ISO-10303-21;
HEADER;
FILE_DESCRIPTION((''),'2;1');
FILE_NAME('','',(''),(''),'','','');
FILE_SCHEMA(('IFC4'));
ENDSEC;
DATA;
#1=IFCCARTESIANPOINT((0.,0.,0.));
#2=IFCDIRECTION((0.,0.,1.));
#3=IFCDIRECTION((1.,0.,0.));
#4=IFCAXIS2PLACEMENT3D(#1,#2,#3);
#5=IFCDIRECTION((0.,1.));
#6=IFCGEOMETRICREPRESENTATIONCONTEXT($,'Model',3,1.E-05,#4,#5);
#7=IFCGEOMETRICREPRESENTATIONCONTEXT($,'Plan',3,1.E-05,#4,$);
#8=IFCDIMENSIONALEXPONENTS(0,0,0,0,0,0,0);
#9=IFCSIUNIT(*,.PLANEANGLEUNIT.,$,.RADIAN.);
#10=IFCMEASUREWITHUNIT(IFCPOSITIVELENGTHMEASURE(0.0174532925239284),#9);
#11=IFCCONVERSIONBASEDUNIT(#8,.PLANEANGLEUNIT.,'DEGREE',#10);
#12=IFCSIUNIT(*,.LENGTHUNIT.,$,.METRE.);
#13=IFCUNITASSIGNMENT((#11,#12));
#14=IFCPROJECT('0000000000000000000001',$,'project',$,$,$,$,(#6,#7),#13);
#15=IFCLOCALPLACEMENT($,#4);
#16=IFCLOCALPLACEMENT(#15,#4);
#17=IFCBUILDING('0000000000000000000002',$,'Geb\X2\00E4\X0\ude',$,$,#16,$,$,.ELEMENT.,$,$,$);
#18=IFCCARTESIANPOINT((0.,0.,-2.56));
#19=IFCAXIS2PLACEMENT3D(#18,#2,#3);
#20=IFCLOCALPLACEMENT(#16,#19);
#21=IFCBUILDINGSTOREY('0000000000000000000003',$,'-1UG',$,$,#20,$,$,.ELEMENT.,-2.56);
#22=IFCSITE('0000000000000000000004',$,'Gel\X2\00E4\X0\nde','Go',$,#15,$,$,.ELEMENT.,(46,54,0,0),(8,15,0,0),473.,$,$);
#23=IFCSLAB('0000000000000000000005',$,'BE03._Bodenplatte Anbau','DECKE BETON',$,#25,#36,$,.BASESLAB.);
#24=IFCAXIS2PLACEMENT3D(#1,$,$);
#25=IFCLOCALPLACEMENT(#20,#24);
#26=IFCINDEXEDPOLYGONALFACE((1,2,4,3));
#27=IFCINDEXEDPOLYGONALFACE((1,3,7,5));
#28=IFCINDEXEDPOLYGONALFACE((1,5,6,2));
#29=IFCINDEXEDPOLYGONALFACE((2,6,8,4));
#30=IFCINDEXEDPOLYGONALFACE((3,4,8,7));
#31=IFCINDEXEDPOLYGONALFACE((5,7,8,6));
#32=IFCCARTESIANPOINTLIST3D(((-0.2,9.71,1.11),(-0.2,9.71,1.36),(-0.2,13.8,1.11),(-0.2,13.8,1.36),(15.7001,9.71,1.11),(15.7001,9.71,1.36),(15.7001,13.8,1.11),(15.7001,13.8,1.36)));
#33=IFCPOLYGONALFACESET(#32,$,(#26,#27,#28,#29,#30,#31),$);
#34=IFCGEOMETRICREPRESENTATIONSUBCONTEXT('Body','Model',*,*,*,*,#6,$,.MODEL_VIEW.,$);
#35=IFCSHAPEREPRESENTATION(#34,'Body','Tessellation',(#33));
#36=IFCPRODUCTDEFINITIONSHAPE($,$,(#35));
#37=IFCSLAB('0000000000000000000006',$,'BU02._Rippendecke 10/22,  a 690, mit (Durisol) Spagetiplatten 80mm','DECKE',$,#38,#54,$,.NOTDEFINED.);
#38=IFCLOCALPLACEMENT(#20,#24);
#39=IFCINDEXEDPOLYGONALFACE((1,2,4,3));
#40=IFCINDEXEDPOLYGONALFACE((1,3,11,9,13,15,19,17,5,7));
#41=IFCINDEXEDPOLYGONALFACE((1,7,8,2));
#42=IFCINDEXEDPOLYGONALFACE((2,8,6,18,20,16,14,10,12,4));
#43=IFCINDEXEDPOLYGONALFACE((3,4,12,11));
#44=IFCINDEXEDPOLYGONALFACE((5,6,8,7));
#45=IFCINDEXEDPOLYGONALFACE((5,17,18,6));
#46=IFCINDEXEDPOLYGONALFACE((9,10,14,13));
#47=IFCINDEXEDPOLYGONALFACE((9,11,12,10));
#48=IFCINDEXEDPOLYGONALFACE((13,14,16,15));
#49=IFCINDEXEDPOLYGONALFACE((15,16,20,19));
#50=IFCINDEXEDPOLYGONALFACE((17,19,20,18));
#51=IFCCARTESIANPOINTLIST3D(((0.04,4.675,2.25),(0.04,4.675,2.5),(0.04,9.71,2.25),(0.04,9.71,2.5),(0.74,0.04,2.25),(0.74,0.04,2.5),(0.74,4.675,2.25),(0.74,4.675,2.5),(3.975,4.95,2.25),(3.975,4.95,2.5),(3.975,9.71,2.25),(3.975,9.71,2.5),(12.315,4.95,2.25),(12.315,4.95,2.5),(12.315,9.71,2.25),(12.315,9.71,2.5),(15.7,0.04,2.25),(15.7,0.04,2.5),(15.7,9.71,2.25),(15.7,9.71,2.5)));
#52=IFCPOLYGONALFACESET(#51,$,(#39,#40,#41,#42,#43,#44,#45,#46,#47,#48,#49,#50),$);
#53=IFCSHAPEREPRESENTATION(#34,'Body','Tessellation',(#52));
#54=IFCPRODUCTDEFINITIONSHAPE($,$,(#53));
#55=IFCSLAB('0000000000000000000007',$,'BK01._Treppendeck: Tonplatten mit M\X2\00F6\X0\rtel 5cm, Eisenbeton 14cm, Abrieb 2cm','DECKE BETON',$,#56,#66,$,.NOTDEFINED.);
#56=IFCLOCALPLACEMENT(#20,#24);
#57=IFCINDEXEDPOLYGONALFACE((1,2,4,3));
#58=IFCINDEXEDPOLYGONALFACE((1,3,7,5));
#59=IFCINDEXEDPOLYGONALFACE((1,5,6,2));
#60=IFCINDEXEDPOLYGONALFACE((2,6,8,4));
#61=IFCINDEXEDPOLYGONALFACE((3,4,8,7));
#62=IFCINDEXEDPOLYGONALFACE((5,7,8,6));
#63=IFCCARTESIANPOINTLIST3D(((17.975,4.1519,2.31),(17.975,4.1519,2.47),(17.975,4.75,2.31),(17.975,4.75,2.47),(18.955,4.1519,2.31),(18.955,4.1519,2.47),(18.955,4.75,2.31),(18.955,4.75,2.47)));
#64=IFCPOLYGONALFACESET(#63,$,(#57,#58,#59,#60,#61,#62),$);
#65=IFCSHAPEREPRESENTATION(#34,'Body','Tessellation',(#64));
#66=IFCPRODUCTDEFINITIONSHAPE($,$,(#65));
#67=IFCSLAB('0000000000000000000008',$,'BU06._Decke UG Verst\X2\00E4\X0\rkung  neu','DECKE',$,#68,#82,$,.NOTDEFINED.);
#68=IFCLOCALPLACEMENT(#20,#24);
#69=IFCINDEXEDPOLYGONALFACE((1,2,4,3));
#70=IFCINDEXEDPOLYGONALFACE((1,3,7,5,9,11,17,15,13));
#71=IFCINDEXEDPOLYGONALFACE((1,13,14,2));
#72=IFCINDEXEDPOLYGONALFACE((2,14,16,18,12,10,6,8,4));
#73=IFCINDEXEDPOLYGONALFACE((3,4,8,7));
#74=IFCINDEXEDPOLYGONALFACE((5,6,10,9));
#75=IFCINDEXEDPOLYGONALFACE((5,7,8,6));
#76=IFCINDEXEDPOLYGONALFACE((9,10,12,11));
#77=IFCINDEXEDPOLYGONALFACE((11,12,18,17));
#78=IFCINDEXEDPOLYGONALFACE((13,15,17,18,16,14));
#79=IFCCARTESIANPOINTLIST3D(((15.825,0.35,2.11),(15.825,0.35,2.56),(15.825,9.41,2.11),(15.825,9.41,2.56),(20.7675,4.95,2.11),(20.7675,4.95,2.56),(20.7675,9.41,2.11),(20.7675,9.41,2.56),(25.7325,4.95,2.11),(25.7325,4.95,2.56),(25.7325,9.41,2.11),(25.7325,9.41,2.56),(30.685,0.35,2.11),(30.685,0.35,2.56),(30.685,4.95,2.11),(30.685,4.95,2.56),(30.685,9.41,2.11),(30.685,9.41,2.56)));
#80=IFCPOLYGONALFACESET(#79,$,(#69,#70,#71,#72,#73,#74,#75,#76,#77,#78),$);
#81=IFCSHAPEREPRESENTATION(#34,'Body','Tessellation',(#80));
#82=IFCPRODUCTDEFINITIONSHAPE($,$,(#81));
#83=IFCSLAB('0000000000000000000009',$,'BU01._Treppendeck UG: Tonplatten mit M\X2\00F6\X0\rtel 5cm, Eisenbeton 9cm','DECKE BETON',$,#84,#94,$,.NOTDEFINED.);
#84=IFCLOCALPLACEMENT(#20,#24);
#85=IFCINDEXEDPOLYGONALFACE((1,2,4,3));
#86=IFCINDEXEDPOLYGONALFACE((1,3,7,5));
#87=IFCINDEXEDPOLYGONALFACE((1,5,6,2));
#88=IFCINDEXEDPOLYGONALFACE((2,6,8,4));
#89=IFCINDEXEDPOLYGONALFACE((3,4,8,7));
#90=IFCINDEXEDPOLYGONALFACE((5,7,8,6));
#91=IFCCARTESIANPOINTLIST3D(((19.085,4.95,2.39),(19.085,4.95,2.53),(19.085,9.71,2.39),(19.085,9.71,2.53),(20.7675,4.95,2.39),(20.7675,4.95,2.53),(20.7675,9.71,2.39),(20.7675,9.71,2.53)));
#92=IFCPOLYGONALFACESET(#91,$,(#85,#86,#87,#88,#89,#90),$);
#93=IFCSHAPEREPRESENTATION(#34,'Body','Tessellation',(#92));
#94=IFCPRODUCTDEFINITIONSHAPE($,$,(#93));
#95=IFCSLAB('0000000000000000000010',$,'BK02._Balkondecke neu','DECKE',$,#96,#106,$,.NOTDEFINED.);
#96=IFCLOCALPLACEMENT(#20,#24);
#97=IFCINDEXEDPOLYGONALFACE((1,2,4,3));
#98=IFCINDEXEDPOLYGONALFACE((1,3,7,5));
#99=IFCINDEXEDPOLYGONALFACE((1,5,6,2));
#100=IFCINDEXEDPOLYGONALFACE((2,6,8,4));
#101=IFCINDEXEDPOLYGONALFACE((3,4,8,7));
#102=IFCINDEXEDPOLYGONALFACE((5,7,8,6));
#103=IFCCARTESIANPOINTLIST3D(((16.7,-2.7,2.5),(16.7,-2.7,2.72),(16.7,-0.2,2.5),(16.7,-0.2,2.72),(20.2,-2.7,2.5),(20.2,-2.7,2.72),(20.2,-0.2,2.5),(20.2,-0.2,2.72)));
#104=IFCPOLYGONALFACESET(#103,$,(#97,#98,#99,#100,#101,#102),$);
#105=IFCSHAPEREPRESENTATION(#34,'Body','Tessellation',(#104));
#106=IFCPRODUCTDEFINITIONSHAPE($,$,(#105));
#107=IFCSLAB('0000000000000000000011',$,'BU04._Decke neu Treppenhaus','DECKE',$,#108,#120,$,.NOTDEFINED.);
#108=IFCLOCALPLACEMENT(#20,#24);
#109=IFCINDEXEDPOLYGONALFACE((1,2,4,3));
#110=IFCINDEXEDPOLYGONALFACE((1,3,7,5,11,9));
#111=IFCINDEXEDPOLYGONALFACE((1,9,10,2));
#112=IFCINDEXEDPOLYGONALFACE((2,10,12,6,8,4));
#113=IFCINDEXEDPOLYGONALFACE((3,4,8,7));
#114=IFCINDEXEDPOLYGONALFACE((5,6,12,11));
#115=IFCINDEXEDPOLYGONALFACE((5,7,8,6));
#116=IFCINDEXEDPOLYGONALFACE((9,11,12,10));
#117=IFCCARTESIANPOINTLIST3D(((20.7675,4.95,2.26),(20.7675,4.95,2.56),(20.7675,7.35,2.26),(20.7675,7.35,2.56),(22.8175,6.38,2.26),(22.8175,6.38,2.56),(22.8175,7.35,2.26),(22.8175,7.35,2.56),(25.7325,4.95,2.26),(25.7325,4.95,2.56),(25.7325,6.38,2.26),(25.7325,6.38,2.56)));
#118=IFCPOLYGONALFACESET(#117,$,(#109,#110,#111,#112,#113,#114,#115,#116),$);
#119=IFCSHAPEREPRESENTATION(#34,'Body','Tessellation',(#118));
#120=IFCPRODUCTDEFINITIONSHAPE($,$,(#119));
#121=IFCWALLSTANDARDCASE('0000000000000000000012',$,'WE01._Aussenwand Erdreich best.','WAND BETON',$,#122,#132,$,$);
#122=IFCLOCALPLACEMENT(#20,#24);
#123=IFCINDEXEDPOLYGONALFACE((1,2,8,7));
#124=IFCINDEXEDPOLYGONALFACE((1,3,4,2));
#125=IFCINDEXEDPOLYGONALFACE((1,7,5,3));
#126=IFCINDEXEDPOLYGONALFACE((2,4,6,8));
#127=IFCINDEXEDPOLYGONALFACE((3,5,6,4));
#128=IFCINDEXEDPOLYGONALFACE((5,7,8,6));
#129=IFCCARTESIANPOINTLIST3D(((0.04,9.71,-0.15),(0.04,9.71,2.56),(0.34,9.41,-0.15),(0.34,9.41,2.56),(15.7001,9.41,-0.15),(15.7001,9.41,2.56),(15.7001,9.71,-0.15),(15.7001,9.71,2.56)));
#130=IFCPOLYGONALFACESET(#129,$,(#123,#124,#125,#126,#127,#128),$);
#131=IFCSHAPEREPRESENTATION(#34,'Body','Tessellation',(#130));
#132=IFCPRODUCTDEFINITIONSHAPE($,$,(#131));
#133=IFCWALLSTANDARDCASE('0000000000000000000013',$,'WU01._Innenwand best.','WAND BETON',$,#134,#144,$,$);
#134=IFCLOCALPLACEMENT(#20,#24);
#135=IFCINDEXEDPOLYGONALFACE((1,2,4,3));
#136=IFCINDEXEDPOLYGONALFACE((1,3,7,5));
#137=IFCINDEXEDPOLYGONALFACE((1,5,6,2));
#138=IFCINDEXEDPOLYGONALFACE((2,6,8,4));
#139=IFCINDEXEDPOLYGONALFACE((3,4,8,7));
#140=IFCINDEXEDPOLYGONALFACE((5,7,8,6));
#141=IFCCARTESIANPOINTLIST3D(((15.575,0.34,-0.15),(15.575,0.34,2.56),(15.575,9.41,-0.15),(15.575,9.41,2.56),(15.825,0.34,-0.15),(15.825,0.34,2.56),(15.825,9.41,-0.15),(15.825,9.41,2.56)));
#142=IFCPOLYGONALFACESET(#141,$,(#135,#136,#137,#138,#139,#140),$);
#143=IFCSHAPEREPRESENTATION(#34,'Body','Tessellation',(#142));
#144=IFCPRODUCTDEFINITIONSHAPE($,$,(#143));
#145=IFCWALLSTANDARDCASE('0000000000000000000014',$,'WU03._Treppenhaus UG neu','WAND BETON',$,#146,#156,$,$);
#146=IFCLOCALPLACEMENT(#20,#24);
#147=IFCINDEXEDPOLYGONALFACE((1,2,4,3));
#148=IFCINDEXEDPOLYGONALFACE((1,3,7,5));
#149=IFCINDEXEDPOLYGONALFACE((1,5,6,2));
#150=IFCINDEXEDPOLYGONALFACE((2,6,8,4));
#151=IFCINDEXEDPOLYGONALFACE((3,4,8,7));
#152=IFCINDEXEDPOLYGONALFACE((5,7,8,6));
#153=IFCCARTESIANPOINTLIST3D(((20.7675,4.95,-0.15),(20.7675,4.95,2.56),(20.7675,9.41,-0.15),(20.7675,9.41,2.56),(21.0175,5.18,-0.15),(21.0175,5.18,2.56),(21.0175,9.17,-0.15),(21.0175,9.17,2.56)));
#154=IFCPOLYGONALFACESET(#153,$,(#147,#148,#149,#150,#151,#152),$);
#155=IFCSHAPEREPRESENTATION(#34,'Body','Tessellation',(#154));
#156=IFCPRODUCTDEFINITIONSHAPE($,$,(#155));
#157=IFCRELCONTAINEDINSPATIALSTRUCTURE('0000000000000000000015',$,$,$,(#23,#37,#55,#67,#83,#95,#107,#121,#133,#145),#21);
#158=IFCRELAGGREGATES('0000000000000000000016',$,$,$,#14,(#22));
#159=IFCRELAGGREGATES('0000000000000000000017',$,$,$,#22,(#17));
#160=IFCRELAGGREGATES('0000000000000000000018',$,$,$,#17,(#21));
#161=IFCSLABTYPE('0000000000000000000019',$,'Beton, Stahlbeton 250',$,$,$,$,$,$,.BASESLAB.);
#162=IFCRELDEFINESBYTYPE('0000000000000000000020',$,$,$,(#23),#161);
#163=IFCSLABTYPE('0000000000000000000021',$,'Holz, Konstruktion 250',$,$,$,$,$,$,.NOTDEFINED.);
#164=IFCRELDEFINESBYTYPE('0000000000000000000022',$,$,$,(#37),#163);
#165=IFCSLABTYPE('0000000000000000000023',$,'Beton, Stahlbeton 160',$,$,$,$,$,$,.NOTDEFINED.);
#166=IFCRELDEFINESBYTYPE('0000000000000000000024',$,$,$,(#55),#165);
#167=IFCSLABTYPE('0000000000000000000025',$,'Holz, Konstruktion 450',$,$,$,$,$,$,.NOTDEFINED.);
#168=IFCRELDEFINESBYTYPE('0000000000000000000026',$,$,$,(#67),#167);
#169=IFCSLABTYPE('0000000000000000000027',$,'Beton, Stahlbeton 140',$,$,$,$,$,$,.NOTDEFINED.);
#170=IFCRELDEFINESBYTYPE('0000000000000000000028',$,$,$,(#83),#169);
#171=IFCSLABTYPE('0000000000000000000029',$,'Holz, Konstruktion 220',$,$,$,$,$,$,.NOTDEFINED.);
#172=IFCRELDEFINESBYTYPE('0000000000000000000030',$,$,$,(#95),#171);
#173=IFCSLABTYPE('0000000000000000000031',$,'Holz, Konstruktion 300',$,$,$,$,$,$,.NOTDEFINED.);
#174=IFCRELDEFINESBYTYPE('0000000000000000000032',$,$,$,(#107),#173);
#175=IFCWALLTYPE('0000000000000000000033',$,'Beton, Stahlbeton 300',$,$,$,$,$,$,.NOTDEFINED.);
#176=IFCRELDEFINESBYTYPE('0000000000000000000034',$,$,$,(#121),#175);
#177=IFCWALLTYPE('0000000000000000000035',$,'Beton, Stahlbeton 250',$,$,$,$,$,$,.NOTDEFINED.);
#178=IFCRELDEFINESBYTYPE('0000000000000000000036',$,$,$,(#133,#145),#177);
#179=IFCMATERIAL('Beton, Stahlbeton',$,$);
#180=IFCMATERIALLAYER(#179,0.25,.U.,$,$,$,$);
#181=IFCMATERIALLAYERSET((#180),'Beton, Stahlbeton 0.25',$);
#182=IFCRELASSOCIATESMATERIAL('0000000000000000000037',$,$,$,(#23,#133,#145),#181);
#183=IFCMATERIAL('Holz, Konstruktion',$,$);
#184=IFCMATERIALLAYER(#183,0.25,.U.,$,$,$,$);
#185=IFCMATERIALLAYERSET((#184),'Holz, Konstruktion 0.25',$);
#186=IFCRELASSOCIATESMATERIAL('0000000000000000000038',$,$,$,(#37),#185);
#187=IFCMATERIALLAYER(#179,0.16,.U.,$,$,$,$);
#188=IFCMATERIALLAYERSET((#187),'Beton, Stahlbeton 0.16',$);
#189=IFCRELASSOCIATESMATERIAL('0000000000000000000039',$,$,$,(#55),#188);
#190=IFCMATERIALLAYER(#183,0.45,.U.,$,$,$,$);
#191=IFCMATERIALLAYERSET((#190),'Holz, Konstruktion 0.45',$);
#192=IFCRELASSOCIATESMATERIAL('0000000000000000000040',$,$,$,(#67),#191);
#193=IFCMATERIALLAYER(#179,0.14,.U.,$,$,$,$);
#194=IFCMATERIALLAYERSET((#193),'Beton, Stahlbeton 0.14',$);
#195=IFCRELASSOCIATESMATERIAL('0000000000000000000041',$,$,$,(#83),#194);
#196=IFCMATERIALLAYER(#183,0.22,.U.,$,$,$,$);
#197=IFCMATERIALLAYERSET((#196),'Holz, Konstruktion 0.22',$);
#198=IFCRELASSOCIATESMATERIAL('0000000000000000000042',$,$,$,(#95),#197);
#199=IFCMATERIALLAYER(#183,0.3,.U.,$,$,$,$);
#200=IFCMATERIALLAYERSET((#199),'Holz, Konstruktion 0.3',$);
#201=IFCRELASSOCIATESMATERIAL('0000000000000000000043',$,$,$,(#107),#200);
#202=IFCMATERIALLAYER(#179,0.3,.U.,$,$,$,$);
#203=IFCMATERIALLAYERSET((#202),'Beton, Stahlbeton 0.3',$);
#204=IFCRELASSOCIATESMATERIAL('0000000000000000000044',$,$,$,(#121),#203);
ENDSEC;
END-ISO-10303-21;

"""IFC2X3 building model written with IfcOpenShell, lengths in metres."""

from ifc_helpers import new_model, entity, si_unit, converted_unit, direction, frame, origin_with_axes, place, context, subcontext, project, spatial, polyline, outline, extrude, material, layer, layer_set, layer_usage, type_object, element, save


model = new_model("IFC2X3")

# Units and contexts
model_context = context("Model", 3, precision=1e-05, world=origin_with_axes(), true_north=direction((0.0, 1.0)))
plan_context = context("Plan", 3, precision=1e-05, world=origin_with_axes())
body_context = subcontext(model_context, "Body", "Model", "MODEL_VIEW")
ifc_project = project(units=[converted_unit("PLANEANGLEUNIT", "DEGREE", entity("IfcPositiveLengthMeasure", 0.0174532925239284), si_unit("PLANEANGLEUNIT", "RADIAN"), dimensions=[0, 0, 0, 0, 0, 0, 0]), si_unit("LENGTHUNIT", "METRE")], contexts=[model_context, plan_context])

# Site, building, storey
site_placement = place(None, origin_with_axes())
site = spatial("IfcSite", under=ifc_project, at=site_placement, Name="Gelände", Description="Go", CompositionType="ELEMENT", RefLatitude=(46, 54, 0, 0), RefLongitude=(8, 15, 0, 0), RefElevation=473.0)
building_placement = place(site_placement, origin_with_axes())
building = spatial("IfcBuilding", under=site, at=building_placement, Name="Gebäude", CompositionType="ELEMENT")
storey_placement = place(building_placement, frame((0.0, 0.0, -2.56), z_axis=(0.0, 0.0, 1.0), x_axis=(1.0, 0.0, 0.0)))
storey = spatial("IfcBuildingStorey", under=building, at=storey_placement, Name="-1UG", CompositionType="ELEMENT", Elevation=-2.56)

# Slabs
ifc_material_1 = material(Name="Beton, Stahlbeton")
ifc_layer_1 = layer(ifc_material_1, 0.25, ventilated="UNKNOWN")
ifc_layer_set_1 = layer_set([ifc_layer_1], Name="Beton, Stahlbeton 0.25")
ifc_layer_usage_1 = layer_usage(ifc_layer_set_1, "AXIS3", "NEGATIVE", 0.25)
slab_type_1 = type_object("IfcSlabType", Name="Beton, Stahlbeton 250", PredefinedType="BASESLAB")
slab_1_placement = place(storey_placement, frame((15.7001, 9.71, 1.36), z_axis=(0.0, 0.0, 1.0), x_axis=(1.0, 0.0, 0.0)))
element("IfcSlab", 1, at=slab_1_placement, inside=storey, type_object=slab_type_1, material=ifc_layer_usage_1, Name="BE03._Bodenplatte Anbau", Description="DECKE BETON", PredefinedType="BASESLAB", context=body_context, shape_type="SweptSolid", body=[
    extrude(outline(polyline([(0.0, 0.0), (0.0, 4.09), (-15.9001, 4.09), (-15.9001, 0.0), (0.0, 0.0)])), frame((0.0, 0.0, -0.25), z_axis=(0.0, 0.0, 1.0), x_axis=(1.0, 0.0, 0.0)), (0.0, 0.0, 1.0), 0.25),
])
ifc_material_2 = material(Name="Holz, Konstruktion")
ifc_layer_2 = layer(ifc_material_2, 0.25, ventilated="UNKNOWN")
ifc_layer_set_2 = layer_set([ifc_layer_2], Name="Holz, Konstruktion 0.25")
ifc_layer_usage_2 = layer_usage(ifc_layer_set_2, "AXIS3", "NEGATIVE", 0.25)
slab_type_2 = type_object("IfcSlabType", Name="Holz, Konstruktion 250", PredefinedType="NOTDEFINED")
slab_2_placement = place(storey_placement, frame((15.7, 0.04, 2.5), z_axis=(0.0, 0.0, 1.0), x_axis=(1.0, 0.0, 0.0)))
element("IfcSlab", 2, at=slab_2_placement, inside=storey, type_object=slab_type_2, material=ifc_layer_usage_2, Name="BU02._Rippendecke 10/22,  a 690, mit (Durisol) Spagetiplatten 80mm", Description="DECKE", PredefinedType="NOTDEFINED", context=body_context, shape_type="SweptSolid", body=[
    extrude(outline(polyline([(0.0, 0.0), (0.0, 9.67), (-3.385, 9.67), (-3.385, 4.91), (-11.725, 4.91), (-11.725, 9.67), (-15.66, 9.67), (-15.66, 4.635), (-14.96, 4.635), (-14.96, 0.0), (0.0, 0.0)])), frame((0.0, 0.0, -0.25), z_axis=(0.0, 0.0, 1.0), x_axis=(1.0, 0.0, 0.0)), (0.0, 0.0, 1.0), 0.25),
])
ifc_layer_3 = layer(ifc_material_1, 0.16, ventilated="UNKNOWN")
ifc_layer_set_3 = layer_set([ifc_layer_3], Name="Beton, Stahlbeton 0.16")
ifc_layer_usage_3 = layer_usage(ifc_layer_set_3, "AXIS3", "NEGATIVE", 0.16)
slab_type_3 = type_object("IfcSlabType", Name="Beton, Stahlbeton 160", PredefinedType="NOTDEFINED")
slab_3_placement = place(storey_placement, frame((18.955, 4.1519, 2.47), z_axis=(0.0, 0.0, 1.0), x_axis=(1.0, 0.0, 0.0)))
element("IfcSlab", 3, at=slab_3_placement, inside=storey, type_object=slab_type_3, material=ifc_layer_usage_3, Name="BK01._Treppendeck: Tonplatten mit Mörtel 5cm, Eisenbeton 14cm, Abrieb 2cm", Description="DECKE BETON", PredefinedType="NOTDEFINED", context=body_context, shape_type="SweptSolid", body=[
    extrude(outline(polyline([(0.0, 0.0), (0.0, 0.5981), (-0.98, 0.5981), (-0.98, 0.0), (0.0, 0.0)])), frame((0.0, 0.0, -0.16), z_axis=(0.0, 0.0, 1.0), x_axis=(1.0, 0.0, 0.0)), (0.0, 0.0, 1.0), 0.16),
])
ifc_layer_4 = layer(ifc_material_2, 0.45, ventilated="UNKNOWN")
ifc_layer_set_4 = layer_set([ifc_layer_4], Name="Holz, Konstruktion 0.45")
ifc_layer_usage_4 = layer_usage(ifc_layer_set_4, "AXIS3", "NEGATIVE", 0.45)
slab_type_4 = type_object("IfcSlabType", Name="Holz, Konstruktion 450", PredefinedType="NOTDEFINED")
slab_4_placement = place(storey_placement, frame((15.825, 0.35, 2.56), z_axis=(0.0, 0.0, 1.0), x_axis=(1.0, 0.0, 0.0)))
element("IfcSlab", 4, at=slab_4_placement, inside=storey, type_object=slab_type_4, material=ifc_layer_usage_4, Name="BU06._Decke UG Verstärkung  neu", Description="DECKE", PredefinedType="NOTDEFINED", context=body_context, shape_type="SweptSolid", body=[
    extrude(outline(polyline([(0.0, 0.0), (14.86, 0.0), (14.86, 4.6), (14.86, 9.06), (9.9075, 9.06), (9.9075, 4.6), (4.9425, 4.6), (4.9425, 9.06), (0.0, 9.06), (0.0, 0.0)])), frame((0.0, 0.0, -0.45), z_axis=(0.0, 0.0, 1.0), x_axis=(1.0, 0.0, 0.0)), (0.0, 0.0, 1.0), 0.45),
])
ifc_layer_5 = layer(ifc_material_1, 0.14, ventilated="UNKNOWN")
ifc_layer_set_5 = layer_set([ifc_layer_5], Name="Beton, Stahlbeton 0.14")
ifc_layer_usage_5 = layer_usage(ifc_layer_set_5, "AXIS3", "NEGATIVE", 0.14)
slab_type_5 = type_object("IfcSlabType", Name="Beton, Stahlbeton 140", PredefinedType="NOTDEFINED")
slab_5_placement = place(storey_placement, frame((19.085, 4.95, 2.53), z_axis=(0.0, 0.0, 1.0), x_axis=(1.0, 0.0, 0.0)))
element("IfcSlab", 5, at=slab_5_placement, inside=storey, type_object=slab_type_5, material=ifc_layer_usage_5, Name="BU01._Treppendeck UG: Tonplatten mit Mörtel 5cm, Eisenbeton 9cm", Description="DECKE BETON", PredefinedType="NOTDEFINED", context=body_context, shape_type="SweptSolid", body=[
    extrude(outline(polyline([(0.0, 0.0), (1.6825, 0.0), (1.6825, 4.76), (0.0, 4.76), (0.0, 0.0)])), frame((0.0, 0.0, -0.14), z_axis=(0.0, 0.0, 1.0), x_axis=(1.0, 0.0, 0.0)), (0.0, 0.0, 1.0), 0.14),
])
ifc_layer_6 = layer(ifc_material_2, 0.22, ventilated="UNKNOWN")
ifc_layer_set_6 = layer_set([ifc_layer_6], Name="Holz, Konstruktion 0.22")
ifc_layer_usage_6 = layer_usage(ifc_layer_set_6, "AXIS3", "NEGATIVE", 0.22)
slab_type_6 = type_object("IfcSlabType", Name="Holz, Konstruktion 220", PredefinedType="NOTDEFINED")
slab_6_placement = place(storey_placement, frame((16.7, -2.7, 2.72), z_axis=(0.0, 0.0, 1.0), x_axis=(1.0, 0.0, 0.0)))
element("IfcSlab", 6, at=slab_6_placement, inside=storey, type_object=slab_type_6, material=ifc_layer_usage_6, Name="BK02._Balkondecke neu", Description="DECKE", PredefinedType="NOTDEFINED", context=body_context, shape_type="SweptSolid", body=[
    extrude(outline(polyline([(0.0, 0.0), (3.5, 0.0), (3.5, 2.5), (0.0, 2.5), (0.0, 0.0)])), frame((0.0, 0.0, -0.22), z_axis=(0.0, 0.0, 1.0), x_axis=(1.0, 0.0, 0.0)), (0.0, 0.0, 1.0), 0.22),
])
ifc_layer_7 = layer(ifc_material_2, 0.3, ventilated="UNKNOWN")
ifc_layer_set_7 = layer_set([ifc_layer_7], Name="Holz, Konstruktion 0.3")
ifc_layer_usage_7 = layer_usage(ifc_layer_set_7, "AXIS3", "NEGATIVE", 0.3)
slab_type_7 = type_object("IfcSlabType", Name="Holz, Konstruktion 300", PredefinedType="NOTDEFINED")
slab_7_placement = place(storey_placement, frame((20.7675, 7.35, 2.56), z_axis=(0.0, 0.0, 1.0), x_axis=(1.0, 0.0, 0.0)))
element("IfcSlab", 7, at=slab_7_placement, inside=storey, type_object=slab_type_7, material=ifc_layer_usage_7, Name="BU04._Decke neu Treppenhaus", Description="DECKE", PredefinedType="NOTDEFINED", context=body_context, shape_type="SweptSolid", body=[
    extrude(outline(polyline([(0.0, 0.0), (0.0, -2.4), (4.965, -2.4), (4.965, -0.97), (2.05, -0.97), (2.05, 0.0), (0.0, 0.0)])), frame((0.0, 0.0, -0.3), z_axis=(0.0, 0.0, 1.0), x_axis=(1.0, 0.0, 0.0)), (0.0, 0.0, 1.0), 0.3),
])

# Walls
ifc_layer_8 = layer(ifc_material_1, 0.3, ventilated="UNKNOWN")
ifc_layer_set_8 = layer_set([ifc_layer_8], Name="Beton, Stahlbeton 0.3")
ifc_layer_usage_8 = layer_usage(ifc_layer_set_8, "AXIS2", "POSITIVE", -0.3)
wall_type_1 = type_object("IfcWallType", Name="Beton, Stahlbeton 300", PredefinedType="NOTDEFINED")
wall_1_placement = place(storey_placement, frame((15.7001, 9.41, -0.15), z_axis=(0.0, 0.0, 1.0), x_axis=(-1.0, 0.0, 0.0)))
element("IfcWallStandardCase", 8, at=wall_1_placement, inside=storey, type_object=wall_type_1, material=ifc_layer_usage_8, Name="WE01._Aussenwand Erdreich best.", Description="WAND BETON", context=body_context, shape_type="SweptSolid", body=[
    extrude(outline(polyline([(0.0, -0.3), (15.6601, -0.3), (15.3601, 0.0), (0.0, 0.0), (0.0, -0.3)])), origin_with_axes(), (0.0, 0.0, 1.0), 2.71),
])
ifc_layer_usage_9 = layer_usage(ifc_layer_set_1, "AXIS2", "NEGATIVE", 0.0)
wall_type_2 = type_object("IfcWallType", Name="Beton, Stahlbeton 250", PredefinedType="NOTDEFINED")
wall_2_placement = place(storey_placement, frame((15.825, 9.41, -0.15), z_axis=(0.0, 0.0, 1.0), x_axis=(0.0, -1.0, 0.0)))
element("IfcWallStandardCase", 9, at=wall_2_placement, inside=storey, type_object=wall_type_2, material=ifc_layer_usage_9, Name="WU01._Innenwand best.", Description="WAND BETON", context=body_context, shape_type="SweptSolid", body=[
    extrude(outline(polyline([(0.0, -0.25), (9.07, -0.25), (9.07, 0.0), (0.0, 0.0), (0.0, -0.25)])), origin_with_axes(), (0.0, 0.0, 1.0), 2.71),
])
ifc_layer_usage_10 = layer_usage(ifc_layer_set_1, "AXIS2", "NEGATIVE", 0.25)
wall_3_placement = place(storey_placement, frame((21.0175, 5.18, -0.15), z_axis=(0.0, 0.0, 1.0), x_axis=(0.0, 1.0, 0.0)))
element("IfcWallStandardCase", 10, at=wall_3_placement, inside=storey, type_object=wall_type_2, material=ifc_layer_usage_10, Name="WU03._Treppenhaus UG neu", Description="WAND BETON", context=body_context, shape_type="SweptSolid", body=[
    extrude(outline(polyline([(0.0, 0.0), (3.99, 0.0), (4.23, 0.25), (-0.23, 0.25), (0.0, 0.0)])), origin_with_axes(), (0.0, 0.0, 1.0), 2.71),
])

save(model, "model.ifc")
